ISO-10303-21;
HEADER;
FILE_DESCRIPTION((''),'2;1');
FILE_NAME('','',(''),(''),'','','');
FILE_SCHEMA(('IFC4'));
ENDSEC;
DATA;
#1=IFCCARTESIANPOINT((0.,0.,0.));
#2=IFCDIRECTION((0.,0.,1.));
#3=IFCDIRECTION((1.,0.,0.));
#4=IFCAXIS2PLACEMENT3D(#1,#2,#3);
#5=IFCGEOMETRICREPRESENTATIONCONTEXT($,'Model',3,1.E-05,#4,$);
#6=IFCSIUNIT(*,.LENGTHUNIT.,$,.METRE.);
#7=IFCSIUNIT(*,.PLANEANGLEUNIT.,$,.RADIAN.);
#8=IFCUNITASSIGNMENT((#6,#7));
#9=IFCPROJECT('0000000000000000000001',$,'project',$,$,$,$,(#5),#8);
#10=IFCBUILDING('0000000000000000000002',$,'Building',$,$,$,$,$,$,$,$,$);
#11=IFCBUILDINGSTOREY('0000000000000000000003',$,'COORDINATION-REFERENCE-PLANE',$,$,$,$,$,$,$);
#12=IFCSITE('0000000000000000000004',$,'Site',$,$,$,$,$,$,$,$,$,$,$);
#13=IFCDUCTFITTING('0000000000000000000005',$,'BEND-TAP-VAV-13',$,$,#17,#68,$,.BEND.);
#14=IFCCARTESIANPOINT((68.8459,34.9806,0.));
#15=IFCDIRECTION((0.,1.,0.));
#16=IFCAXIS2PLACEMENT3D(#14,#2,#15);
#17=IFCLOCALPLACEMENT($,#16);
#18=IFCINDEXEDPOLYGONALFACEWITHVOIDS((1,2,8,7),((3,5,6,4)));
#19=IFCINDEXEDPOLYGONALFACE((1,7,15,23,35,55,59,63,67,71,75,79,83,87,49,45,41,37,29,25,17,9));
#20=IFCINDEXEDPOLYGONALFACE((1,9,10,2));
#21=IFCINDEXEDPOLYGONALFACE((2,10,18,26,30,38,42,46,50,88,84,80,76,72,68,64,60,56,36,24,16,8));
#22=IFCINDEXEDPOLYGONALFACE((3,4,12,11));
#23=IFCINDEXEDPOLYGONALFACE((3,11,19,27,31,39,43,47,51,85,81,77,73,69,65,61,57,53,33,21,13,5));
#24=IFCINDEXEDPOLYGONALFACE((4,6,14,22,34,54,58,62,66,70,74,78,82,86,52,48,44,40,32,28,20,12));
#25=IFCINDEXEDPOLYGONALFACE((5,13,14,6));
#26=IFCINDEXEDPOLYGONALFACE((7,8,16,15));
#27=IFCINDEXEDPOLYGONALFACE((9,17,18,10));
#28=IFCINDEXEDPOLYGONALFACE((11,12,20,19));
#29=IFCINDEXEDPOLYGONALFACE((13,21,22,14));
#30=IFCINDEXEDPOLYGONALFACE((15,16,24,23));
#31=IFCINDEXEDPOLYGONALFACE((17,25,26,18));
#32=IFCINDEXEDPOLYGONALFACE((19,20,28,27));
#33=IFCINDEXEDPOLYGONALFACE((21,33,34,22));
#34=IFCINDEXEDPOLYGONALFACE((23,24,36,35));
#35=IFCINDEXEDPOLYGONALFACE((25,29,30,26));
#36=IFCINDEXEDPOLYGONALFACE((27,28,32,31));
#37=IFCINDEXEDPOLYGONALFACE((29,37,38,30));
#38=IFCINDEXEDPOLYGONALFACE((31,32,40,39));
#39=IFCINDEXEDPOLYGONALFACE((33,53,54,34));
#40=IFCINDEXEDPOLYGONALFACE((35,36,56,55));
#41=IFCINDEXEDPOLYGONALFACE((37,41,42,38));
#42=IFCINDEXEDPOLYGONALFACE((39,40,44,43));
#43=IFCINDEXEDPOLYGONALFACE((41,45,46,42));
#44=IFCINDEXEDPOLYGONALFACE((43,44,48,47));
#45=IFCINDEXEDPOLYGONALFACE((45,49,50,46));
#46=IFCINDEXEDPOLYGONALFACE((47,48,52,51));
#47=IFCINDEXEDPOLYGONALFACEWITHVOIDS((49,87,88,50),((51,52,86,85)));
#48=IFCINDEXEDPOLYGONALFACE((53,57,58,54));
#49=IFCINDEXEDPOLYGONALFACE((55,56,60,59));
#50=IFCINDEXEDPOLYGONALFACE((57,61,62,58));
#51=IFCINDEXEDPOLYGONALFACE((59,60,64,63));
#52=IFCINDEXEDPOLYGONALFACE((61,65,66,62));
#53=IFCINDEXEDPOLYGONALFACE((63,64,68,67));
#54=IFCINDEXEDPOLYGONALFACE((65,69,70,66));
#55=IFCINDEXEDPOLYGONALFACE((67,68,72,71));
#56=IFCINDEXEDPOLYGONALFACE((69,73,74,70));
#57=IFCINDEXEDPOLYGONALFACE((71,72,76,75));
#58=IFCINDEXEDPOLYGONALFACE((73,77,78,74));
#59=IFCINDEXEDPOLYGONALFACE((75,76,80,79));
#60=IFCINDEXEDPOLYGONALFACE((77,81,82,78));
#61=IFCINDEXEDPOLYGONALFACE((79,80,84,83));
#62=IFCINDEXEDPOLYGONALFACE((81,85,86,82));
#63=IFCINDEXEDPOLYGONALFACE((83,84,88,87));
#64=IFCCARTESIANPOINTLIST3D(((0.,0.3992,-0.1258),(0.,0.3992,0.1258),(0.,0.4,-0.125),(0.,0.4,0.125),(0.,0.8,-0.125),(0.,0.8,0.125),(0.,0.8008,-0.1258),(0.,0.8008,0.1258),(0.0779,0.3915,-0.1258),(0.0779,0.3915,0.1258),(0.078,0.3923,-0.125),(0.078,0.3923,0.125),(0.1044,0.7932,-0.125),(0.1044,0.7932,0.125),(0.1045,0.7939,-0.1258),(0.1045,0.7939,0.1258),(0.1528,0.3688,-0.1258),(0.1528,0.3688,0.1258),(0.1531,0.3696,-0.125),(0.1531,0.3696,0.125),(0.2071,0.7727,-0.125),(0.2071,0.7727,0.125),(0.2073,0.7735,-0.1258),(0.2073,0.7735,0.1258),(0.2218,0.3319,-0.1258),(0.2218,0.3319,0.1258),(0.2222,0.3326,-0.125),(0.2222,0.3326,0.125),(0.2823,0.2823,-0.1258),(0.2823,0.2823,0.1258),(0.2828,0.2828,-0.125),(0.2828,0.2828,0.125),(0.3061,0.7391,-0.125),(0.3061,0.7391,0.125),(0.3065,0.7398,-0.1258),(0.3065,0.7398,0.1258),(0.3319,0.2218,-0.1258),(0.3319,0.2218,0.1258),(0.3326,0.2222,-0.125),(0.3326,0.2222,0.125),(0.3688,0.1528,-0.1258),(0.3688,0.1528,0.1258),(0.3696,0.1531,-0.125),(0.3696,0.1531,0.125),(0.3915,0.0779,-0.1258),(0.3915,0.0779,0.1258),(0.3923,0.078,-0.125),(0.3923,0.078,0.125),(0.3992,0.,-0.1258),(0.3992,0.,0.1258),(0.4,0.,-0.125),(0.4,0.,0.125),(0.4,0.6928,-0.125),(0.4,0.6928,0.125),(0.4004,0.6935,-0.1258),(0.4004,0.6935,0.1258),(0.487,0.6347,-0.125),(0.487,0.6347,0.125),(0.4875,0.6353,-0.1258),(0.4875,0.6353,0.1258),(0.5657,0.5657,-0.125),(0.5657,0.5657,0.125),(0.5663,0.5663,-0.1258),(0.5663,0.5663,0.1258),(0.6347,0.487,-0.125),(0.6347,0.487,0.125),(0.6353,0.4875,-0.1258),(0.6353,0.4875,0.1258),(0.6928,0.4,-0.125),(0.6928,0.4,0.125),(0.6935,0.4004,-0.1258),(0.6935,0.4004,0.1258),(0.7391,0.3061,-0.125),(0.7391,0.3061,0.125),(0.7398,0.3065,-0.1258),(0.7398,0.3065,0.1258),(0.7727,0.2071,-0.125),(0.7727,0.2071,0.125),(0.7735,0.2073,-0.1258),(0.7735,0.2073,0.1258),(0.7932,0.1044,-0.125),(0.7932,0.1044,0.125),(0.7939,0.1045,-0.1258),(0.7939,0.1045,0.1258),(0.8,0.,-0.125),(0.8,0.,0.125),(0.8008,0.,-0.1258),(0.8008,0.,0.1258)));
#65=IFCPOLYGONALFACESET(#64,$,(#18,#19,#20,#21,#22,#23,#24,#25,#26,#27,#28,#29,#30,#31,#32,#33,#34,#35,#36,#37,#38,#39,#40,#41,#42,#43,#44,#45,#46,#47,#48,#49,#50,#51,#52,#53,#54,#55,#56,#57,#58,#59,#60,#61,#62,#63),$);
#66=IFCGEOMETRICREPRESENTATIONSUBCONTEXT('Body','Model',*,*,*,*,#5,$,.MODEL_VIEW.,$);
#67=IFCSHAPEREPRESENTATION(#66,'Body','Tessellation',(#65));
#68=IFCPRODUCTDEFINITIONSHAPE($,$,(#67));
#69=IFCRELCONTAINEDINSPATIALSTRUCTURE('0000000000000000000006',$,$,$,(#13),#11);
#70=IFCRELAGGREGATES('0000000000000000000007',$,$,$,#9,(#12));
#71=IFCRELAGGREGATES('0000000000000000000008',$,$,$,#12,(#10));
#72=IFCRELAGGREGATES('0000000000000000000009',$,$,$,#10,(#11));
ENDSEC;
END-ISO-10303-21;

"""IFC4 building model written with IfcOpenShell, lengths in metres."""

from ifc_helpers import new_model, entity, si_unit, frame, origin_with_axes, place, context, subcontext, project, spatial, element, save


model = new_model("IFC4")

# Units and contexts
model_context = context("Model", 3, precision=1e-05, world=origin_with_axes())
body_context = subcontext(model_context, "Body", "Model", "MODEL_VIEW")
ifc_project = project(units=[si_unit("LENGTHUNIT", "METRE"), si_unit("PLANEANGLEUNIT", "RADIAN")], contexts=[model_context])

# Site, building, storey
site = spatial("IfcSite", under=ifc_project, Name="Site")
building = spatial("IfcBuilding", under=site, Name="Building")
storey = spatial("IfcBuildingStorey", under=building, Name="COORDINATION-REFERENCE-PLANE")

# Duct fitting
duct_fitting_1_placement = place(None, frame((68.8459, 34.9806, 0.0), z_axis=(0.0, 0.0, 1.0), x_axis=(0.0, 1.0, 0.0)))
cartesian_point_1 = entity("IfcCartesianPoint", [0.0, 0.0, 0.0])
element("IfcDuctFitting", 1, at=duct_fitting_1_placement, inside=storey, Name="BEND-TAP-VAV-13", PredefinedType="BEND", context=body_context, shape_type="SweptSolid", body=[
    entity("IfcRevolvedAreaSolid", entity("IfcRectangleHollowProfileDef", "AREA", None, entity("IfcAxis2Placement2D", entity("IfcCartesianPoint", [0.6, 0.0])), 0.4016, 0.2516, 0.0008), entity("IfcAxis2Placement3D", cartesian_point_1, entity("IfcDirection", [0.0, -1.0, 0.0]), entity("IfcDirection", [1.0, 0.0, 0.0])), entity("IfcAxis1Placement", cartesian_point_1, entity("IfcDirection", [0.0, 1.0, 0.0])), 1.570796),
])

save(model, "model.ifc")
